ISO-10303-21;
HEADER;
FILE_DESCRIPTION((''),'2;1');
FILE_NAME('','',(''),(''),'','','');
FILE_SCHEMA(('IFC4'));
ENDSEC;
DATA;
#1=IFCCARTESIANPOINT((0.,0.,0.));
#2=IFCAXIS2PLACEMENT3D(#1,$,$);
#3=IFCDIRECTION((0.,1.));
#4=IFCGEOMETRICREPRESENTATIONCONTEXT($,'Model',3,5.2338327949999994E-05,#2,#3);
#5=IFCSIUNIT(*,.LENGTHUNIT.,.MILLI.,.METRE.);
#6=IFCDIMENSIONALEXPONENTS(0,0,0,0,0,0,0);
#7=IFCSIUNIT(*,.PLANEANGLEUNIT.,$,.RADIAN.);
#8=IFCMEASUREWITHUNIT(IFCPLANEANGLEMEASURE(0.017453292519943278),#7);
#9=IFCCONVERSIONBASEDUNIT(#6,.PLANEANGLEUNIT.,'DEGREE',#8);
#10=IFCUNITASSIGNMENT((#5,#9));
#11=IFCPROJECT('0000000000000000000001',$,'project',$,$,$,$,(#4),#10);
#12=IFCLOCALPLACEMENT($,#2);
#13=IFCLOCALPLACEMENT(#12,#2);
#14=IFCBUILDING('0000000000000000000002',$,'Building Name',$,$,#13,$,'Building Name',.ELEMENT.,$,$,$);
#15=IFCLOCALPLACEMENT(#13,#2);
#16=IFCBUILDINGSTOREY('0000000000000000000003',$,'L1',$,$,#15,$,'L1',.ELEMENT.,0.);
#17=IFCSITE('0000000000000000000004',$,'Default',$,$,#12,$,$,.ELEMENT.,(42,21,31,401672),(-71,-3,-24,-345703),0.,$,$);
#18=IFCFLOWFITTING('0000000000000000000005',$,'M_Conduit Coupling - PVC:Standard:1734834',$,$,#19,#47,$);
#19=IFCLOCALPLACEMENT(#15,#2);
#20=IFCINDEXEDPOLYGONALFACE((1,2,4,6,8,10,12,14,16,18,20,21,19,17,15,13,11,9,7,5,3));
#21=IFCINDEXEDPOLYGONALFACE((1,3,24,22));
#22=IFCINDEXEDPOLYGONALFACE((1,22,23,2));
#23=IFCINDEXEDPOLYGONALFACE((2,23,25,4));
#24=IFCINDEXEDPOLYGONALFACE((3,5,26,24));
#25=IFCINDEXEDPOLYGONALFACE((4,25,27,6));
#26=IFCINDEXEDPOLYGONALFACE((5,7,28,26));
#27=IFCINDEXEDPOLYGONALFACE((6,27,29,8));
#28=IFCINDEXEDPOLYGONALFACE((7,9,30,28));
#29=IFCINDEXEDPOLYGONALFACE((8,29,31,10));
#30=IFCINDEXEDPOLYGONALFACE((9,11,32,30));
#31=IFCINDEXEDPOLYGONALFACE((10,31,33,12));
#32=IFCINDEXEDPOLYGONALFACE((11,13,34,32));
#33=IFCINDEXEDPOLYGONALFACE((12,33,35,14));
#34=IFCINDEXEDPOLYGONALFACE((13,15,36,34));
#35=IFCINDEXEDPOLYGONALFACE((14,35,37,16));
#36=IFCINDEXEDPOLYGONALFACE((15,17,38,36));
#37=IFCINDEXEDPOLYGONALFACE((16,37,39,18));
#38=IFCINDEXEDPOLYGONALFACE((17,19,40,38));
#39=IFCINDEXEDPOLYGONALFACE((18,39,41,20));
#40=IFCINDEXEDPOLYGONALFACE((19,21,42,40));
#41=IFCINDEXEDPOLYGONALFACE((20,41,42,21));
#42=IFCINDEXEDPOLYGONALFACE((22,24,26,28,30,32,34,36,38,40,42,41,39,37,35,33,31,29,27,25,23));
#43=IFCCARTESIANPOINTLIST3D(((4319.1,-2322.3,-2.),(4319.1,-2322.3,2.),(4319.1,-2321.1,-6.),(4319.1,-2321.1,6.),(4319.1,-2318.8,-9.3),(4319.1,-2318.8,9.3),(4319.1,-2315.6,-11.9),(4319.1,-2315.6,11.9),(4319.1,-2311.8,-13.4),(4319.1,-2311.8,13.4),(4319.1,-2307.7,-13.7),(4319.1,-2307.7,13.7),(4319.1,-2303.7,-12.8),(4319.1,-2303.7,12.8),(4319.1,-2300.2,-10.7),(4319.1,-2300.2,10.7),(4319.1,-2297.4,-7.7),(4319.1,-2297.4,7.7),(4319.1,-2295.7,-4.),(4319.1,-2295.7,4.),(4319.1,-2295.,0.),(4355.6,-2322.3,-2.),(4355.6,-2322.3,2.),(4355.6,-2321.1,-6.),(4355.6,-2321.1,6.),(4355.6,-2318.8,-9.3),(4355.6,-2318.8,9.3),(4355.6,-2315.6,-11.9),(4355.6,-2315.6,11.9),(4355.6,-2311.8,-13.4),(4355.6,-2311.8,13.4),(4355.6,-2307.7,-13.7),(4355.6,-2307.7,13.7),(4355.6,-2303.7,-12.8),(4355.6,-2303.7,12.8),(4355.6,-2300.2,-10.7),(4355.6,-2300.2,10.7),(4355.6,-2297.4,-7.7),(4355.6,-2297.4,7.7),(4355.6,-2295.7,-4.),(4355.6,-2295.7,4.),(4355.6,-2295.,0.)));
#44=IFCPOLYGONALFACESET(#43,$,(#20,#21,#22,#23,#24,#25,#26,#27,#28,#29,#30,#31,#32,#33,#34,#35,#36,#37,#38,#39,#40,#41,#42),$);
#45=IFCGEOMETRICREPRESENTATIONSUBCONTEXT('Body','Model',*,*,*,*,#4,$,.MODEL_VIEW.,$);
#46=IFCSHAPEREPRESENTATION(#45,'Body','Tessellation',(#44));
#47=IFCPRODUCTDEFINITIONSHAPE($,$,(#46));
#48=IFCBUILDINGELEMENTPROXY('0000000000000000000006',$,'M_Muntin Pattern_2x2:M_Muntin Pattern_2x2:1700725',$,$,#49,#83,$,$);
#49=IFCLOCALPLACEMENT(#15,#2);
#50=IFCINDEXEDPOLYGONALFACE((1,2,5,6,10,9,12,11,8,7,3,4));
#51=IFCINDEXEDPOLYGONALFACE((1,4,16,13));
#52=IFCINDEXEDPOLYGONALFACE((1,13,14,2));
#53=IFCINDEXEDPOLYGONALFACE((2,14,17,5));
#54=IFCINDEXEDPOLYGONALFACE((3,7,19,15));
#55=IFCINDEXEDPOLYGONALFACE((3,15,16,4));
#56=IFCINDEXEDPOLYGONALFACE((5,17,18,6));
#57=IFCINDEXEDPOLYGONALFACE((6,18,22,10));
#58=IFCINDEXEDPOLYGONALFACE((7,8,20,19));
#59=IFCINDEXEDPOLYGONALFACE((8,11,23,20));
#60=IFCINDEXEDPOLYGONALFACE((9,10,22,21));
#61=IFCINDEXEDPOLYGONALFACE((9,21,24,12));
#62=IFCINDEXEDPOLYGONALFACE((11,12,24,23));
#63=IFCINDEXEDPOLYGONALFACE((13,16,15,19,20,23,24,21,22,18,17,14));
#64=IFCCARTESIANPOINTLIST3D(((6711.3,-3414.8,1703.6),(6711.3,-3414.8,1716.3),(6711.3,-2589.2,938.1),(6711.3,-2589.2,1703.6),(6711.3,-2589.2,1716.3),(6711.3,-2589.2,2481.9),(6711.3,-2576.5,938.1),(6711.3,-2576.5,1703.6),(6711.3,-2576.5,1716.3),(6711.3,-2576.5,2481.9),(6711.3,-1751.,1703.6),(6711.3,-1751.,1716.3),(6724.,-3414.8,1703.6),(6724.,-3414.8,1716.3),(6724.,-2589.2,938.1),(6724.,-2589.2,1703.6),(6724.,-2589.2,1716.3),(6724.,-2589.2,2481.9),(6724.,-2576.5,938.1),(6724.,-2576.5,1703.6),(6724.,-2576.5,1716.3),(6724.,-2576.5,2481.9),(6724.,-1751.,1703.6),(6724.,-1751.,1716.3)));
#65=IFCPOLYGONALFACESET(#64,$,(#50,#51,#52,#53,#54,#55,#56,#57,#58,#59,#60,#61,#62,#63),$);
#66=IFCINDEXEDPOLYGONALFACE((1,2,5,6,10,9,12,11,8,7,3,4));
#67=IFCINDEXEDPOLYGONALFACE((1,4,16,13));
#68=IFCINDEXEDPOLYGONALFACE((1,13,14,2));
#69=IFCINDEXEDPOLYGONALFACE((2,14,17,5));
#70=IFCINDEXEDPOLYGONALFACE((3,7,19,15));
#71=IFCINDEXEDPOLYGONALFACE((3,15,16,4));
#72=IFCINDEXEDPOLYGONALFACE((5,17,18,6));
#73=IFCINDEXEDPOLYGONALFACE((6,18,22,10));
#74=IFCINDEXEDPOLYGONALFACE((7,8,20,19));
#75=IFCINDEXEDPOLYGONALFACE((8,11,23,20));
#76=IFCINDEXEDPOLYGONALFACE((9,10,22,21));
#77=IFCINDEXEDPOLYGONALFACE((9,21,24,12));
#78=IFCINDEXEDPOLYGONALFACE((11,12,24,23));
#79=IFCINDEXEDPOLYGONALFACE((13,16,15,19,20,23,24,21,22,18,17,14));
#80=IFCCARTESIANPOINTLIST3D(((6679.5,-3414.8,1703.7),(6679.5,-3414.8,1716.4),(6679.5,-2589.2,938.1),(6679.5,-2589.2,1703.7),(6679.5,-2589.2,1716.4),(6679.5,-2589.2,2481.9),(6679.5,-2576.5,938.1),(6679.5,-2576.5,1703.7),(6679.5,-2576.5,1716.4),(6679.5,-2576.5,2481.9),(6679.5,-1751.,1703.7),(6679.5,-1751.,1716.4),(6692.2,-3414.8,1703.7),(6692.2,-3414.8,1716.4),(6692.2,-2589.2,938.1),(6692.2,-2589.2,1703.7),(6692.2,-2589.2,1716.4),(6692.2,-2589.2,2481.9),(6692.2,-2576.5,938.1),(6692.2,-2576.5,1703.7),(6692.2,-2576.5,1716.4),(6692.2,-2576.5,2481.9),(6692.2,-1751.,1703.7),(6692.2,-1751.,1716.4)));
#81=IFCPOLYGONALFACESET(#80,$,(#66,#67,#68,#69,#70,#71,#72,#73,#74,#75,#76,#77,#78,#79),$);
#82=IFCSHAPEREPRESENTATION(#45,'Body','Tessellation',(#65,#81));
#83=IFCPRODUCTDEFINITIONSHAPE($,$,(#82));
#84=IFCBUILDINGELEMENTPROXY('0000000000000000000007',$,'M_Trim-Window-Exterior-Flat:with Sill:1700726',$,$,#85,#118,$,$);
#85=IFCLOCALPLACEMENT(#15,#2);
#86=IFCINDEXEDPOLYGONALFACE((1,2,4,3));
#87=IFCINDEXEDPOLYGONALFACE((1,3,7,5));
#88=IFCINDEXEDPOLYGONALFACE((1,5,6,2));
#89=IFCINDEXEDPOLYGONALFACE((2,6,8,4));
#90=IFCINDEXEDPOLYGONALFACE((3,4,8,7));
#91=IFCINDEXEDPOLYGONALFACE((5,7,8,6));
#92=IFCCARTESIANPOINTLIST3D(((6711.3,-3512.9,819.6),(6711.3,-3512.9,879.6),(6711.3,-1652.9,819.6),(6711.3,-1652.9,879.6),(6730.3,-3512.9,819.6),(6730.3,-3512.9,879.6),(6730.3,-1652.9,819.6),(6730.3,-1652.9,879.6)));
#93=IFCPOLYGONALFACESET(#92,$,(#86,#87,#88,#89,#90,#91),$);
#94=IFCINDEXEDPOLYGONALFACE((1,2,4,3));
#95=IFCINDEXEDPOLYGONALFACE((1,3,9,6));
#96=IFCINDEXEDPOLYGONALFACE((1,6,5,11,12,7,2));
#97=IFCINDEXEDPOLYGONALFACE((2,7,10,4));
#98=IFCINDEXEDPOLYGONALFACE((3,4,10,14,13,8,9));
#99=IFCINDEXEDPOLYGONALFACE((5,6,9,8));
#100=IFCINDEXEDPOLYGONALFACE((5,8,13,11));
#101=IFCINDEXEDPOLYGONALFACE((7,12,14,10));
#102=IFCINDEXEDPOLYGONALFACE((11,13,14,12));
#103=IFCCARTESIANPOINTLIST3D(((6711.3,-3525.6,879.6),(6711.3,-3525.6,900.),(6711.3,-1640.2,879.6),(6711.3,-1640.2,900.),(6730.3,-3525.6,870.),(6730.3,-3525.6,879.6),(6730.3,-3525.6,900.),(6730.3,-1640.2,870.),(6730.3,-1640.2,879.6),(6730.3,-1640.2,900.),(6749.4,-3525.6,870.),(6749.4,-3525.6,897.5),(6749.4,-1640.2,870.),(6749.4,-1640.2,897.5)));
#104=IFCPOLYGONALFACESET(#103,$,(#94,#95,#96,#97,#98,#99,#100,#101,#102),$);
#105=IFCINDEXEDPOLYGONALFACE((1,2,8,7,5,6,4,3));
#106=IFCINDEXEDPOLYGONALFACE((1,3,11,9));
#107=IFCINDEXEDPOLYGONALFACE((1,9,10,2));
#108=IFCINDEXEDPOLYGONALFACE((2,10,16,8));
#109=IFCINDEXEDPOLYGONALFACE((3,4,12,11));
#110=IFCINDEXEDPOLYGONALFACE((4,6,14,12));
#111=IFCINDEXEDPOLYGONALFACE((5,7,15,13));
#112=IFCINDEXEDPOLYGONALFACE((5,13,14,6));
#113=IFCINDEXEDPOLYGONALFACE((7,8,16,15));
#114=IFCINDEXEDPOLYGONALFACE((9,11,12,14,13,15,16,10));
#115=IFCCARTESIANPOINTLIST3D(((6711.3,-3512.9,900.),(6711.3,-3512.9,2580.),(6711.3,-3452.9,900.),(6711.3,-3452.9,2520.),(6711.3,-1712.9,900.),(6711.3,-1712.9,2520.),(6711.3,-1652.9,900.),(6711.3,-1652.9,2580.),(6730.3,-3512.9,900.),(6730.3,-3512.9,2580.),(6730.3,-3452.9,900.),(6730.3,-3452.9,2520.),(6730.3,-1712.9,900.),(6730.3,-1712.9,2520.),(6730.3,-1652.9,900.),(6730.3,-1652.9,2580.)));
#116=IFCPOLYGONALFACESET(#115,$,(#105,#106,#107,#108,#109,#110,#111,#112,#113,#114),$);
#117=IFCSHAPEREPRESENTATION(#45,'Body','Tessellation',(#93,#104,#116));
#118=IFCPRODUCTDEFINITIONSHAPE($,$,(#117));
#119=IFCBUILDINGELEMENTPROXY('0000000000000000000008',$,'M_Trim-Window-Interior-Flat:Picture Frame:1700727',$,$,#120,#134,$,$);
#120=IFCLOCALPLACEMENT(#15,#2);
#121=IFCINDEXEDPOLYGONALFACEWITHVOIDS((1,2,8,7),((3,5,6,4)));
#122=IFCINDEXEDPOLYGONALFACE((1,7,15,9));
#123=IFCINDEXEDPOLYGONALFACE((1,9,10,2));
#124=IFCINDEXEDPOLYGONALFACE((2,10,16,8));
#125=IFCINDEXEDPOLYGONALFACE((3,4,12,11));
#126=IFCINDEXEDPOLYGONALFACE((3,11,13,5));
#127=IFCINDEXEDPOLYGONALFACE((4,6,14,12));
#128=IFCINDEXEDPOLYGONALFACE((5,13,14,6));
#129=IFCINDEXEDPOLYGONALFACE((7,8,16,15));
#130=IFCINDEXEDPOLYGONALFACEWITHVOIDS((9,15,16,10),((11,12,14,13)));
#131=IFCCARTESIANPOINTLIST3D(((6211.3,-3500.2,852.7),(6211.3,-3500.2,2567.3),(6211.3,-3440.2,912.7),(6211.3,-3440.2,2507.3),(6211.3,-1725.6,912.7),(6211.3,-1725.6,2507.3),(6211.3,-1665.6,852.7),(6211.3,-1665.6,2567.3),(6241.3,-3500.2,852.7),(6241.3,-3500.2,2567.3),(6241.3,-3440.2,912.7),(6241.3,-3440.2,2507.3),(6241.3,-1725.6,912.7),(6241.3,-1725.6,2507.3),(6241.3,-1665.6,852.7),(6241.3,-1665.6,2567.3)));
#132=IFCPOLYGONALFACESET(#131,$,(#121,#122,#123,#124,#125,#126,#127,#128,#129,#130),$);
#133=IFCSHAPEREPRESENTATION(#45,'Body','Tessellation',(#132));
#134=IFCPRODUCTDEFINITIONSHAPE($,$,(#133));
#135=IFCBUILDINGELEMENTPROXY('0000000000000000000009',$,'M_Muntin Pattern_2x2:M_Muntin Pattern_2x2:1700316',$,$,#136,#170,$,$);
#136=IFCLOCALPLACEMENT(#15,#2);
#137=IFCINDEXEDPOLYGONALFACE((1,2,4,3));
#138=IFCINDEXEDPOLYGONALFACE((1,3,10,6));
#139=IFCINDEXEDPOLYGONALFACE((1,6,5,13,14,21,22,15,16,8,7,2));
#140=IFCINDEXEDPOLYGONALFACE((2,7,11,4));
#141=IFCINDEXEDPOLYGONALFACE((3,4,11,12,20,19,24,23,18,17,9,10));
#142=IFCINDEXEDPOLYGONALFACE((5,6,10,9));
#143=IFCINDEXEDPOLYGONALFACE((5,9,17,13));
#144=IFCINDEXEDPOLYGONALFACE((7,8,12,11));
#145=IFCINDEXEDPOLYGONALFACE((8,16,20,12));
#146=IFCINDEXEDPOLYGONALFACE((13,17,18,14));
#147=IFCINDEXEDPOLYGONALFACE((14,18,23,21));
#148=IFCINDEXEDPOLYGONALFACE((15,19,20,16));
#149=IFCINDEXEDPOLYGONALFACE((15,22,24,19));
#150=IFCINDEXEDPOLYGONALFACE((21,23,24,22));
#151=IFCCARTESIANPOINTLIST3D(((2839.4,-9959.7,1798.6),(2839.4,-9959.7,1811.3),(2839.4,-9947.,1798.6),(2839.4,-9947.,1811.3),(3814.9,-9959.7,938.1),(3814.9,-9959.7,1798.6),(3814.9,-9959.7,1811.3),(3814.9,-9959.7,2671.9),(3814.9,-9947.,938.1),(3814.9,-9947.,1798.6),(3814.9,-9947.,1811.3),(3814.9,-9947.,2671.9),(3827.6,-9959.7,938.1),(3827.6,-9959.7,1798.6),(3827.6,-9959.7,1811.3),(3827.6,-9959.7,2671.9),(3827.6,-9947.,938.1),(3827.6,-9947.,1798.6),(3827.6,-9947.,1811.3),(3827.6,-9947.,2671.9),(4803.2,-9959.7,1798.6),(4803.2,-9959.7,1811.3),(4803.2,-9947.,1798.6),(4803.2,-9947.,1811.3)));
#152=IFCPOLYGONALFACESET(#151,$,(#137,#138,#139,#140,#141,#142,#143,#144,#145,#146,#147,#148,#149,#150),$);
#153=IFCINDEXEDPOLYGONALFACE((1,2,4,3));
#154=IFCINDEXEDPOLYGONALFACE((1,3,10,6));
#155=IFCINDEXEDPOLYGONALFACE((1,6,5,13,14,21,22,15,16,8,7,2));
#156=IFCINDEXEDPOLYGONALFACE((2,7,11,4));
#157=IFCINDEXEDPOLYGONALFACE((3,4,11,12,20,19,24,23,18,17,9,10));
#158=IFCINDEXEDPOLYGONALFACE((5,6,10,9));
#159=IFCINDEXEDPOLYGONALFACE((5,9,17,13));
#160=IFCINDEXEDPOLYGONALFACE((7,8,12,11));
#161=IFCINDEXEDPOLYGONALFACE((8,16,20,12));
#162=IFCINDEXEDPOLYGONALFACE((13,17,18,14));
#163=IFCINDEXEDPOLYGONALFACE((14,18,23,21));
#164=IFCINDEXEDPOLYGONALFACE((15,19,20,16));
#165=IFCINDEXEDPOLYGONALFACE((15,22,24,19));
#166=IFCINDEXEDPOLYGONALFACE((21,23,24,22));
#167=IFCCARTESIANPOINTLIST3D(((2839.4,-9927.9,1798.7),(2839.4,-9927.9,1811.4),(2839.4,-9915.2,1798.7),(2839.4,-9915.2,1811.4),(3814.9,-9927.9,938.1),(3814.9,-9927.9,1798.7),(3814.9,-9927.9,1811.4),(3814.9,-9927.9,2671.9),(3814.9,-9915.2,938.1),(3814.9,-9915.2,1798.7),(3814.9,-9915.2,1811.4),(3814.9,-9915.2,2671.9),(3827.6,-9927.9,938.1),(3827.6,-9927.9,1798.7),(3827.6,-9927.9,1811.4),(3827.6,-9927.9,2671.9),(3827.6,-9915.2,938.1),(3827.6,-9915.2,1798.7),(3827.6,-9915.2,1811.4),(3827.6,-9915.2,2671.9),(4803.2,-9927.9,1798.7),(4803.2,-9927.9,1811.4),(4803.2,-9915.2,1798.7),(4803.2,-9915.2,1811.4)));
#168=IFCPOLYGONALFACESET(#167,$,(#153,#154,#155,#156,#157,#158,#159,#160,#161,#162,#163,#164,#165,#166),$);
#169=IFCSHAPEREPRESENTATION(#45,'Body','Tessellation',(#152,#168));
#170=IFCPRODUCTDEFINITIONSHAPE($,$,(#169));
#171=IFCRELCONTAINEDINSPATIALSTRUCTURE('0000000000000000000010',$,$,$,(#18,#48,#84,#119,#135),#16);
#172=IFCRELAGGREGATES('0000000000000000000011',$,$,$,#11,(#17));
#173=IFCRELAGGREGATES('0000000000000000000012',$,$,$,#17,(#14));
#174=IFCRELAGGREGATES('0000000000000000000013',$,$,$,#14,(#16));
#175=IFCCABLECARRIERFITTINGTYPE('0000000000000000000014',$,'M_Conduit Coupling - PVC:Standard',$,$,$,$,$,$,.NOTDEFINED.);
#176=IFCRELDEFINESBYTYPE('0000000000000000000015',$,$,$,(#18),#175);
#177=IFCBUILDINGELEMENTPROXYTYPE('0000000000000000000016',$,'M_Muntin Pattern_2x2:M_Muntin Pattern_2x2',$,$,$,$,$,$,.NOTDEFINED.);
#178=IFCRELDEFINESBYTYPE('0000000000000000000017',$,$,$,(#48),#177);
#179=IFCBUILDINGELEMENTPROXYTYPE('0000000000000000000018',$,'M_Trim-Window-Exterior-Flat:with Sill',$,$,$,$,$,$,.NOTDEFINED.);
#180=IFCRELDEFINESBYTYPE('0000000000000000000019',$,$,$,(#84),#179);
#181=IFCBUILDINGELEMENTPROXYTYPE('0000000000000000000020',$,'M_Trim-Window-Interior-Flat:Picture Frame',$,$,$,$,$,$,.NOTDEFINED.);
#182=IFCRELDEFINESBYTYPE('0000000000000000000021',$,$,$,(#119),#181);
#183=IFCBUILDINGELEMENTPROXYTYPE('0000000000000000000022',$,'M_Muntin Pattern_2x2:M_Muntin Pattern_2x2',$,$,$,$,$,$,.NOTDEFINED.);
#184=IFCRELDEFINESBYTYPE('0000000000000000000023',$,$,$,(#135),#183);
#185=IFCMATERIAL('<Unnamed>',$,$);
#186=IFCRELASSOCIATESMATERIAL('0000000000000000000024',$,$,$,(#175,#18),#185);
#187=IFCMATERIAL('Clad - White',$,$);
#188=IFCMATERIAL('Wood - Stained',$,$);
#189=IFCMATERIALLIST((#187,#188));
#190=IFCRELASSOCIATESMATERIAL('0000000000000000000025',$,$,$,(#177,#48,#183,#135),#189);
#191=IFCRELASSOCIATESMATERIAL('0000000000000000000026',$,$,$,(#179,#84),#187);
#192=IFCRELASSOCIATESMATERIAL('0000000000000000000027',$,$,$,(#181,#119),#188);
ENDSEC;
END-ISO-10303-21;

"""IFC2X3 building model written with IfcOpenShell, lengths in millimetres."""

from ifc_helpers import new_model, entity, si_unit, converted_unit, direction, frame, frame_2d, origin, origin_2d_with_axis, place, context, subcontext, project, spatial, polyline, rectangle, circle, outline, extrude, source, transform, mapped, material, material_list, type_object, type_shapes, element, save


model = new_model("IFC2X3")

# Units and contexts
model_context = context("Model", 3, precision=5.2338327949999994e-05, world=origin(), true_north=direction((0.0, 1.0)))
body_context = subcontext(model_context, "Body", "Model", "MODEL_VIEW")
ifc_project = project(units=[si_unit("LENGTHUNIT", "METRE", prefix="MILLI"), converted_unit("PLANEANGLEUNIT", "DEGREE", entity("IfcPlaneAngleMeasure", 0.017453292519943278), si_unit("PLANEANGLEUNIT", "RADIAN"), dimensions=[0, 0, 0, 0, 0, 0, 0])], contexts=[model_context])

# Site, building, storey
site_placement = place(None, origin())
site = spatial("IfcSite", under=ifc_project, at=site_placement, Name="Default", CompositionType="ELEMENT", RefLatitude=(42, 21, 31, 401672), RefLongitude=(-71, -3, -24, -345703), RefElevation=0.0)
building_placement = place(site_placement, origin())
building = spatial("IfcBuilding", under=site, at=building_placement, Name="Building Name", LongName="Building Name", CompositionType="ELEMENT")
storey_placement = place(building_placement, origin())
storey = spatial("IfcBuildingStorey", under=building, at=storey_placement, Name="L1", LongName="L1", CompositionType="ELEMENT", Elevation=0.0)

# Shared definitions
ifc_material_1 = material(Name="<Unnamed>")

# Flow fitting
cable_carrier_fitting_type = type_object("IfcCableCarrierFittingType", Name="M_Conduit Coupling - PVC:Standard", PredefinedType="NOTDEFINED", material=ifc_material_1)
shared_shape_1 = source(origin(), body_context, "Body", "SweptSolid", [
    extrude(circle(Radius=13.7, at=frame_2d((0.0, 0.0), x_axis=(1.0, 0.0))), frame((0.0, 0.0, 0.0), z_axis=(1.0, 0.0, 0.0), x_axis=(0.0, 1.0, 0.0)), (0.0, 0.0, 1.0), 36.5),
])
type_shapes(cable_carrier_fitting_type, [shared_shape_1])
for number, where, name in (
    (1, (4319.1, -2308.8, 0.0), "M_Conduit Coupling - PVC:Standard:1734834"),
):
    element("IfcFlowFitting", number, at=place(storey_placement, frame(where)), inside=storey, type_object=cable_carrier_fitting_type, material=ifc_material_1, Name=name, context=body_context, shape_type="MappedRepresentation", body=[
        mapped(shared_shape_1, transform((0.0, 0.0, 0.0), scale=1.0)),
    ])

# Building element proxies
ifc_material_2 = material(Name="Clad - White")
ifc_material_3 = material(Name="Wood - Stained")
ifc_material_list = material_list([ifc_material_2, ifc_material_3])
building_element_proxy_type_1 = type_object("IfcBuildingElementProxyType", Name="M_Muntin Pattern_2x2:M_Muntin Pattern_2x2", PredefinedType="NOTDEFINED", material=ifc_material_list)
shared_shape_2 = source(origin(), body_context, "Body", "SweptSolid", [
    extrude(outline(polyline([(6.4, -6.4), (771.9, -6.4), (771.9, 6.3), (6.4, 6.3), (6.4, 831.9), (-6.3, 831.9), (-6.3, 6.3), (-771.9, 6.3), (-771.9, -6.4), (-6.3, -6.4), (-6.3, -831.9), (6.4, -831.9), (6.4, -6.4)])), frame((0.0, -22.2, 771.9), z_axis=(0.0, 1.0, 0.0), x_axis=(0.0, 0.0, 1.0)), (0.0, 0.0, 1.0), 12.7),
    extrude(outline(polyline([(6.4, -6.4), (771.9, -6.4), (771.9, 6.3), (6.4, 6.3), (6.4, 831.9), (-6.3, 831.9), (-6.3, 6.3), (-771.9, 6.3), (-771.9, -6.4), (-6.3, -6.4), (-6.3, -831.9), (6.4, -831.9), (6.4, -6.4)])), frame((0.0, 9.5, 771.9), z_axis=(0.0, 1.0, 0.0), x_axis=(0.0, 0.0, 1.0)), (0.0, 0.0, 1.0), 12.7),
])
type_shapes(building_element_proxy_type_1, [shared_shape_2])
proxy_1_placement = place(storey_placement, frame((6701.7, -2582.9, 938.1), z_axis=(0.0, 0.0, 1.0), x_axis=(0.0, 1.0, 0.0)))
element("IfcBuildingElementProxy", 2, at=proxy_1_placement, inside=storey, type_object=building_element_proxy_type_1, material=ifc_material_list, Name="M_Muntin Pattern_2x2:M_Muntin Pattern_2x2:1700725", context=body_context, shape_type="MappedRepresentation", body=[
    mapped(shared_shape_2, transform((0.0, 0.0, 0.0), scale=1.0)),
])
building_element_proxy_type_2 = type_object("IfcBuildingElementProxyType", Name="M_Trim-Window-Exterior-Flat:with Sill", PredefinedType="NOTDEFINED", material=ifc_material_2)
shared_shape_3 = source(origin(), body_context, "Body", "SweptSolid", [
    extrude(rectangle(XDim=1860.0, YDim=60.0, at=origin_2d_with_axis()), frame((0.0, -1670.4, 0.0), z_axis=(0.0, 0.0, 1.0), x_axis=(-1.0, 0.0, 0.0)), (0.0, 0.0, 1.0), 19.0),
    extrude(outline(polyline([(-19.0, -15.2), (0.0, -15.2), (0.0, -5.7), (19.0, -5.7), (19.0, 14.8), (0.0, 14.8), (-19.0, 12.3), (-19.0, -15.2)])), frame((-942.7, -1634.8, 19.0), z_axis=(1.0, 0.0, 0.0), x_axis=(0.0, 0.0, -1.0)), (0.0, 0.0, 1.0), 1885.4),
    extrude(outline(polyline([(-855.0, -930.0), (825.0, -930.0), (825.0, -870.0), (-795.0, -870.0), (-795.0, 870.0), (825.0, 870.0), (825.0, 930.0), (-855.0, 930.0), (-855.0, -930.0)])), frame((0.0, -795.0, 0.0), z_axis=(0.0, 0.0, 1.0), x_axis=(0.0, -1.0, 0.0)), (0.0, 0.0, 1.0), 19.0),
])
type_shapes(building_element_proxy_type_2, [shared_shape_3])
proxy_2_placement = place(storey_placement, frame((6711.3, -2582.9, 2520.0), z_axis=(1.0, 0.0, 0.0), x_axis=(0.0, 1.0, 0.0)))
element("IfcBuildingElementProxy", 3, at=proxy_2_placement, inside=storey, type_object=building_element_proxy_type_2, material=ifc_material_2, Name="M_Trim-Window-Exterior-Flat:with Sill:1700726", context=body_context, shape_type="MappedRepresentation", body=[
    mapped(shared_shape_3, transform((0.0, 0.0, 0.0), scale=1.0)),
])
building_element_proxy_type_3 = type_object("IfcBuildingElementProxyType", Name="M_Trim-Window-Interior-Flat:Picture Frame", PredefinedType="NOTDEFINED", material=ifc_material_3)
shared_shape_4 = source(origin(), body_context, "Body", "SweptSolid", [
    extrude(outline(polyline([(-917.3, -857.3), (917.3, -857.3), (917.3, 857.3), (-917.3, 857.3), (-917.3, -857.3)]), holes=[polyline([(-857.3, -797.3), (-857.3, 797.3), (857.3, 797.3), (857.3, -797.3), (-857.3, -797.3)])]), frame((0.0, -810.0, 0.0), z_axis=(0.0, 0.0, 1.0), x_axis=(-1.0, 0.0, 0.0)), (0.0, 0.0, 1.0), 30.0),
])
type_shapes(building_element_proxy_type_3, [shared_shape_4])
proxy_3_placement = place(storey_placement, frame((6241.3, -2582.9, 2520.0), z_axis=(-1.0, 0.0, 0.0), x_axis=(0.0, -1.0, 0.0)))
element("IfcBuildingElementProxy", 4, at=proxy_3_placement, inside=storey, type_object=building_element_proxy_type_3, material=ifc_material_3, Name="M_Trim-Window-Interior-Flat:Picture Frame:1700727", context=body_context, shape_type="MappedRepresentation", body=[
    mapped(shared_shape_4, transform((0.0, 0.0, 0.0), scale=1.0)),
])
building_element_proxy_type_4 = type_object("IfcBuildingElementProxyType", Name="M_Muntin Pattern_2x2:M_Muntin Pattern_2x2", PredefinedType="NOTDEFINED", material=ifc_material_list)
shared_shape_5 = source(origin(), body_context, "Body", "SweptSolid", [
    extrude(outline(polyline([(6.4, -6.4), (866.9, -6.4), (866.9, 6.3), (6.4, 6.3), (6.4, 981.9), (-6.3, 981.9), (-6.3, 6.3), (-866.9, 6.3), (-866.9, -6.4), (-6.3, -6.4), (-6.3, -981.9), (6.4, -981.9), (6.4, -6.4)])), frame((0.0, -22.2, 866.9), z_axis=(0.0, 1.0, 0.0), x_axis=(0.0, 0.0, 1.0)), (0.0, 0.0, 1.0), 12.7),
    extrude(outline(polyline([(6.4, -6.4), (866.9, -6.4), (866.9, 6.3), (6.4, 6.3), (6.4, 981.9), (-6.3, 981.9), (-6.3, 6.3), (-866.9, 6.3), (-866.9, -6.4), (-6.3, -6.4), (-6.3, -981.9), (6.4, -981.9), (6.4, -6.4)])), frame((0.0, 9.5, 866.9), z_axis=(0.0, 1.0, 0.0), x_axis=(0.0, 0.0, 1.0)), (0.0, 0.0, 1.0), 12.7),
])
type_shapes(building_element_proxy_type_4, [shared_shape_5])
proxy_4_placement = place(storey_placement, frame((3821.3, -9937.4, 938.1)))
element("IfcBuildingElementProxy", 5, at=proxy_4_placement, inside=storey, type_object=building_element_proxy_type_4, material=ifc_material_list, Name="M_Muntin Pattern_2x2:M_Muntin Pattern_2x2:1700316", context=body_context, shape_type="MappedRepresentation", body=[
    mapped(shared_shape_5, transform((0.0, 0.0, 0.0), scale=1.0)),
])

save(model, "model.ifc")
